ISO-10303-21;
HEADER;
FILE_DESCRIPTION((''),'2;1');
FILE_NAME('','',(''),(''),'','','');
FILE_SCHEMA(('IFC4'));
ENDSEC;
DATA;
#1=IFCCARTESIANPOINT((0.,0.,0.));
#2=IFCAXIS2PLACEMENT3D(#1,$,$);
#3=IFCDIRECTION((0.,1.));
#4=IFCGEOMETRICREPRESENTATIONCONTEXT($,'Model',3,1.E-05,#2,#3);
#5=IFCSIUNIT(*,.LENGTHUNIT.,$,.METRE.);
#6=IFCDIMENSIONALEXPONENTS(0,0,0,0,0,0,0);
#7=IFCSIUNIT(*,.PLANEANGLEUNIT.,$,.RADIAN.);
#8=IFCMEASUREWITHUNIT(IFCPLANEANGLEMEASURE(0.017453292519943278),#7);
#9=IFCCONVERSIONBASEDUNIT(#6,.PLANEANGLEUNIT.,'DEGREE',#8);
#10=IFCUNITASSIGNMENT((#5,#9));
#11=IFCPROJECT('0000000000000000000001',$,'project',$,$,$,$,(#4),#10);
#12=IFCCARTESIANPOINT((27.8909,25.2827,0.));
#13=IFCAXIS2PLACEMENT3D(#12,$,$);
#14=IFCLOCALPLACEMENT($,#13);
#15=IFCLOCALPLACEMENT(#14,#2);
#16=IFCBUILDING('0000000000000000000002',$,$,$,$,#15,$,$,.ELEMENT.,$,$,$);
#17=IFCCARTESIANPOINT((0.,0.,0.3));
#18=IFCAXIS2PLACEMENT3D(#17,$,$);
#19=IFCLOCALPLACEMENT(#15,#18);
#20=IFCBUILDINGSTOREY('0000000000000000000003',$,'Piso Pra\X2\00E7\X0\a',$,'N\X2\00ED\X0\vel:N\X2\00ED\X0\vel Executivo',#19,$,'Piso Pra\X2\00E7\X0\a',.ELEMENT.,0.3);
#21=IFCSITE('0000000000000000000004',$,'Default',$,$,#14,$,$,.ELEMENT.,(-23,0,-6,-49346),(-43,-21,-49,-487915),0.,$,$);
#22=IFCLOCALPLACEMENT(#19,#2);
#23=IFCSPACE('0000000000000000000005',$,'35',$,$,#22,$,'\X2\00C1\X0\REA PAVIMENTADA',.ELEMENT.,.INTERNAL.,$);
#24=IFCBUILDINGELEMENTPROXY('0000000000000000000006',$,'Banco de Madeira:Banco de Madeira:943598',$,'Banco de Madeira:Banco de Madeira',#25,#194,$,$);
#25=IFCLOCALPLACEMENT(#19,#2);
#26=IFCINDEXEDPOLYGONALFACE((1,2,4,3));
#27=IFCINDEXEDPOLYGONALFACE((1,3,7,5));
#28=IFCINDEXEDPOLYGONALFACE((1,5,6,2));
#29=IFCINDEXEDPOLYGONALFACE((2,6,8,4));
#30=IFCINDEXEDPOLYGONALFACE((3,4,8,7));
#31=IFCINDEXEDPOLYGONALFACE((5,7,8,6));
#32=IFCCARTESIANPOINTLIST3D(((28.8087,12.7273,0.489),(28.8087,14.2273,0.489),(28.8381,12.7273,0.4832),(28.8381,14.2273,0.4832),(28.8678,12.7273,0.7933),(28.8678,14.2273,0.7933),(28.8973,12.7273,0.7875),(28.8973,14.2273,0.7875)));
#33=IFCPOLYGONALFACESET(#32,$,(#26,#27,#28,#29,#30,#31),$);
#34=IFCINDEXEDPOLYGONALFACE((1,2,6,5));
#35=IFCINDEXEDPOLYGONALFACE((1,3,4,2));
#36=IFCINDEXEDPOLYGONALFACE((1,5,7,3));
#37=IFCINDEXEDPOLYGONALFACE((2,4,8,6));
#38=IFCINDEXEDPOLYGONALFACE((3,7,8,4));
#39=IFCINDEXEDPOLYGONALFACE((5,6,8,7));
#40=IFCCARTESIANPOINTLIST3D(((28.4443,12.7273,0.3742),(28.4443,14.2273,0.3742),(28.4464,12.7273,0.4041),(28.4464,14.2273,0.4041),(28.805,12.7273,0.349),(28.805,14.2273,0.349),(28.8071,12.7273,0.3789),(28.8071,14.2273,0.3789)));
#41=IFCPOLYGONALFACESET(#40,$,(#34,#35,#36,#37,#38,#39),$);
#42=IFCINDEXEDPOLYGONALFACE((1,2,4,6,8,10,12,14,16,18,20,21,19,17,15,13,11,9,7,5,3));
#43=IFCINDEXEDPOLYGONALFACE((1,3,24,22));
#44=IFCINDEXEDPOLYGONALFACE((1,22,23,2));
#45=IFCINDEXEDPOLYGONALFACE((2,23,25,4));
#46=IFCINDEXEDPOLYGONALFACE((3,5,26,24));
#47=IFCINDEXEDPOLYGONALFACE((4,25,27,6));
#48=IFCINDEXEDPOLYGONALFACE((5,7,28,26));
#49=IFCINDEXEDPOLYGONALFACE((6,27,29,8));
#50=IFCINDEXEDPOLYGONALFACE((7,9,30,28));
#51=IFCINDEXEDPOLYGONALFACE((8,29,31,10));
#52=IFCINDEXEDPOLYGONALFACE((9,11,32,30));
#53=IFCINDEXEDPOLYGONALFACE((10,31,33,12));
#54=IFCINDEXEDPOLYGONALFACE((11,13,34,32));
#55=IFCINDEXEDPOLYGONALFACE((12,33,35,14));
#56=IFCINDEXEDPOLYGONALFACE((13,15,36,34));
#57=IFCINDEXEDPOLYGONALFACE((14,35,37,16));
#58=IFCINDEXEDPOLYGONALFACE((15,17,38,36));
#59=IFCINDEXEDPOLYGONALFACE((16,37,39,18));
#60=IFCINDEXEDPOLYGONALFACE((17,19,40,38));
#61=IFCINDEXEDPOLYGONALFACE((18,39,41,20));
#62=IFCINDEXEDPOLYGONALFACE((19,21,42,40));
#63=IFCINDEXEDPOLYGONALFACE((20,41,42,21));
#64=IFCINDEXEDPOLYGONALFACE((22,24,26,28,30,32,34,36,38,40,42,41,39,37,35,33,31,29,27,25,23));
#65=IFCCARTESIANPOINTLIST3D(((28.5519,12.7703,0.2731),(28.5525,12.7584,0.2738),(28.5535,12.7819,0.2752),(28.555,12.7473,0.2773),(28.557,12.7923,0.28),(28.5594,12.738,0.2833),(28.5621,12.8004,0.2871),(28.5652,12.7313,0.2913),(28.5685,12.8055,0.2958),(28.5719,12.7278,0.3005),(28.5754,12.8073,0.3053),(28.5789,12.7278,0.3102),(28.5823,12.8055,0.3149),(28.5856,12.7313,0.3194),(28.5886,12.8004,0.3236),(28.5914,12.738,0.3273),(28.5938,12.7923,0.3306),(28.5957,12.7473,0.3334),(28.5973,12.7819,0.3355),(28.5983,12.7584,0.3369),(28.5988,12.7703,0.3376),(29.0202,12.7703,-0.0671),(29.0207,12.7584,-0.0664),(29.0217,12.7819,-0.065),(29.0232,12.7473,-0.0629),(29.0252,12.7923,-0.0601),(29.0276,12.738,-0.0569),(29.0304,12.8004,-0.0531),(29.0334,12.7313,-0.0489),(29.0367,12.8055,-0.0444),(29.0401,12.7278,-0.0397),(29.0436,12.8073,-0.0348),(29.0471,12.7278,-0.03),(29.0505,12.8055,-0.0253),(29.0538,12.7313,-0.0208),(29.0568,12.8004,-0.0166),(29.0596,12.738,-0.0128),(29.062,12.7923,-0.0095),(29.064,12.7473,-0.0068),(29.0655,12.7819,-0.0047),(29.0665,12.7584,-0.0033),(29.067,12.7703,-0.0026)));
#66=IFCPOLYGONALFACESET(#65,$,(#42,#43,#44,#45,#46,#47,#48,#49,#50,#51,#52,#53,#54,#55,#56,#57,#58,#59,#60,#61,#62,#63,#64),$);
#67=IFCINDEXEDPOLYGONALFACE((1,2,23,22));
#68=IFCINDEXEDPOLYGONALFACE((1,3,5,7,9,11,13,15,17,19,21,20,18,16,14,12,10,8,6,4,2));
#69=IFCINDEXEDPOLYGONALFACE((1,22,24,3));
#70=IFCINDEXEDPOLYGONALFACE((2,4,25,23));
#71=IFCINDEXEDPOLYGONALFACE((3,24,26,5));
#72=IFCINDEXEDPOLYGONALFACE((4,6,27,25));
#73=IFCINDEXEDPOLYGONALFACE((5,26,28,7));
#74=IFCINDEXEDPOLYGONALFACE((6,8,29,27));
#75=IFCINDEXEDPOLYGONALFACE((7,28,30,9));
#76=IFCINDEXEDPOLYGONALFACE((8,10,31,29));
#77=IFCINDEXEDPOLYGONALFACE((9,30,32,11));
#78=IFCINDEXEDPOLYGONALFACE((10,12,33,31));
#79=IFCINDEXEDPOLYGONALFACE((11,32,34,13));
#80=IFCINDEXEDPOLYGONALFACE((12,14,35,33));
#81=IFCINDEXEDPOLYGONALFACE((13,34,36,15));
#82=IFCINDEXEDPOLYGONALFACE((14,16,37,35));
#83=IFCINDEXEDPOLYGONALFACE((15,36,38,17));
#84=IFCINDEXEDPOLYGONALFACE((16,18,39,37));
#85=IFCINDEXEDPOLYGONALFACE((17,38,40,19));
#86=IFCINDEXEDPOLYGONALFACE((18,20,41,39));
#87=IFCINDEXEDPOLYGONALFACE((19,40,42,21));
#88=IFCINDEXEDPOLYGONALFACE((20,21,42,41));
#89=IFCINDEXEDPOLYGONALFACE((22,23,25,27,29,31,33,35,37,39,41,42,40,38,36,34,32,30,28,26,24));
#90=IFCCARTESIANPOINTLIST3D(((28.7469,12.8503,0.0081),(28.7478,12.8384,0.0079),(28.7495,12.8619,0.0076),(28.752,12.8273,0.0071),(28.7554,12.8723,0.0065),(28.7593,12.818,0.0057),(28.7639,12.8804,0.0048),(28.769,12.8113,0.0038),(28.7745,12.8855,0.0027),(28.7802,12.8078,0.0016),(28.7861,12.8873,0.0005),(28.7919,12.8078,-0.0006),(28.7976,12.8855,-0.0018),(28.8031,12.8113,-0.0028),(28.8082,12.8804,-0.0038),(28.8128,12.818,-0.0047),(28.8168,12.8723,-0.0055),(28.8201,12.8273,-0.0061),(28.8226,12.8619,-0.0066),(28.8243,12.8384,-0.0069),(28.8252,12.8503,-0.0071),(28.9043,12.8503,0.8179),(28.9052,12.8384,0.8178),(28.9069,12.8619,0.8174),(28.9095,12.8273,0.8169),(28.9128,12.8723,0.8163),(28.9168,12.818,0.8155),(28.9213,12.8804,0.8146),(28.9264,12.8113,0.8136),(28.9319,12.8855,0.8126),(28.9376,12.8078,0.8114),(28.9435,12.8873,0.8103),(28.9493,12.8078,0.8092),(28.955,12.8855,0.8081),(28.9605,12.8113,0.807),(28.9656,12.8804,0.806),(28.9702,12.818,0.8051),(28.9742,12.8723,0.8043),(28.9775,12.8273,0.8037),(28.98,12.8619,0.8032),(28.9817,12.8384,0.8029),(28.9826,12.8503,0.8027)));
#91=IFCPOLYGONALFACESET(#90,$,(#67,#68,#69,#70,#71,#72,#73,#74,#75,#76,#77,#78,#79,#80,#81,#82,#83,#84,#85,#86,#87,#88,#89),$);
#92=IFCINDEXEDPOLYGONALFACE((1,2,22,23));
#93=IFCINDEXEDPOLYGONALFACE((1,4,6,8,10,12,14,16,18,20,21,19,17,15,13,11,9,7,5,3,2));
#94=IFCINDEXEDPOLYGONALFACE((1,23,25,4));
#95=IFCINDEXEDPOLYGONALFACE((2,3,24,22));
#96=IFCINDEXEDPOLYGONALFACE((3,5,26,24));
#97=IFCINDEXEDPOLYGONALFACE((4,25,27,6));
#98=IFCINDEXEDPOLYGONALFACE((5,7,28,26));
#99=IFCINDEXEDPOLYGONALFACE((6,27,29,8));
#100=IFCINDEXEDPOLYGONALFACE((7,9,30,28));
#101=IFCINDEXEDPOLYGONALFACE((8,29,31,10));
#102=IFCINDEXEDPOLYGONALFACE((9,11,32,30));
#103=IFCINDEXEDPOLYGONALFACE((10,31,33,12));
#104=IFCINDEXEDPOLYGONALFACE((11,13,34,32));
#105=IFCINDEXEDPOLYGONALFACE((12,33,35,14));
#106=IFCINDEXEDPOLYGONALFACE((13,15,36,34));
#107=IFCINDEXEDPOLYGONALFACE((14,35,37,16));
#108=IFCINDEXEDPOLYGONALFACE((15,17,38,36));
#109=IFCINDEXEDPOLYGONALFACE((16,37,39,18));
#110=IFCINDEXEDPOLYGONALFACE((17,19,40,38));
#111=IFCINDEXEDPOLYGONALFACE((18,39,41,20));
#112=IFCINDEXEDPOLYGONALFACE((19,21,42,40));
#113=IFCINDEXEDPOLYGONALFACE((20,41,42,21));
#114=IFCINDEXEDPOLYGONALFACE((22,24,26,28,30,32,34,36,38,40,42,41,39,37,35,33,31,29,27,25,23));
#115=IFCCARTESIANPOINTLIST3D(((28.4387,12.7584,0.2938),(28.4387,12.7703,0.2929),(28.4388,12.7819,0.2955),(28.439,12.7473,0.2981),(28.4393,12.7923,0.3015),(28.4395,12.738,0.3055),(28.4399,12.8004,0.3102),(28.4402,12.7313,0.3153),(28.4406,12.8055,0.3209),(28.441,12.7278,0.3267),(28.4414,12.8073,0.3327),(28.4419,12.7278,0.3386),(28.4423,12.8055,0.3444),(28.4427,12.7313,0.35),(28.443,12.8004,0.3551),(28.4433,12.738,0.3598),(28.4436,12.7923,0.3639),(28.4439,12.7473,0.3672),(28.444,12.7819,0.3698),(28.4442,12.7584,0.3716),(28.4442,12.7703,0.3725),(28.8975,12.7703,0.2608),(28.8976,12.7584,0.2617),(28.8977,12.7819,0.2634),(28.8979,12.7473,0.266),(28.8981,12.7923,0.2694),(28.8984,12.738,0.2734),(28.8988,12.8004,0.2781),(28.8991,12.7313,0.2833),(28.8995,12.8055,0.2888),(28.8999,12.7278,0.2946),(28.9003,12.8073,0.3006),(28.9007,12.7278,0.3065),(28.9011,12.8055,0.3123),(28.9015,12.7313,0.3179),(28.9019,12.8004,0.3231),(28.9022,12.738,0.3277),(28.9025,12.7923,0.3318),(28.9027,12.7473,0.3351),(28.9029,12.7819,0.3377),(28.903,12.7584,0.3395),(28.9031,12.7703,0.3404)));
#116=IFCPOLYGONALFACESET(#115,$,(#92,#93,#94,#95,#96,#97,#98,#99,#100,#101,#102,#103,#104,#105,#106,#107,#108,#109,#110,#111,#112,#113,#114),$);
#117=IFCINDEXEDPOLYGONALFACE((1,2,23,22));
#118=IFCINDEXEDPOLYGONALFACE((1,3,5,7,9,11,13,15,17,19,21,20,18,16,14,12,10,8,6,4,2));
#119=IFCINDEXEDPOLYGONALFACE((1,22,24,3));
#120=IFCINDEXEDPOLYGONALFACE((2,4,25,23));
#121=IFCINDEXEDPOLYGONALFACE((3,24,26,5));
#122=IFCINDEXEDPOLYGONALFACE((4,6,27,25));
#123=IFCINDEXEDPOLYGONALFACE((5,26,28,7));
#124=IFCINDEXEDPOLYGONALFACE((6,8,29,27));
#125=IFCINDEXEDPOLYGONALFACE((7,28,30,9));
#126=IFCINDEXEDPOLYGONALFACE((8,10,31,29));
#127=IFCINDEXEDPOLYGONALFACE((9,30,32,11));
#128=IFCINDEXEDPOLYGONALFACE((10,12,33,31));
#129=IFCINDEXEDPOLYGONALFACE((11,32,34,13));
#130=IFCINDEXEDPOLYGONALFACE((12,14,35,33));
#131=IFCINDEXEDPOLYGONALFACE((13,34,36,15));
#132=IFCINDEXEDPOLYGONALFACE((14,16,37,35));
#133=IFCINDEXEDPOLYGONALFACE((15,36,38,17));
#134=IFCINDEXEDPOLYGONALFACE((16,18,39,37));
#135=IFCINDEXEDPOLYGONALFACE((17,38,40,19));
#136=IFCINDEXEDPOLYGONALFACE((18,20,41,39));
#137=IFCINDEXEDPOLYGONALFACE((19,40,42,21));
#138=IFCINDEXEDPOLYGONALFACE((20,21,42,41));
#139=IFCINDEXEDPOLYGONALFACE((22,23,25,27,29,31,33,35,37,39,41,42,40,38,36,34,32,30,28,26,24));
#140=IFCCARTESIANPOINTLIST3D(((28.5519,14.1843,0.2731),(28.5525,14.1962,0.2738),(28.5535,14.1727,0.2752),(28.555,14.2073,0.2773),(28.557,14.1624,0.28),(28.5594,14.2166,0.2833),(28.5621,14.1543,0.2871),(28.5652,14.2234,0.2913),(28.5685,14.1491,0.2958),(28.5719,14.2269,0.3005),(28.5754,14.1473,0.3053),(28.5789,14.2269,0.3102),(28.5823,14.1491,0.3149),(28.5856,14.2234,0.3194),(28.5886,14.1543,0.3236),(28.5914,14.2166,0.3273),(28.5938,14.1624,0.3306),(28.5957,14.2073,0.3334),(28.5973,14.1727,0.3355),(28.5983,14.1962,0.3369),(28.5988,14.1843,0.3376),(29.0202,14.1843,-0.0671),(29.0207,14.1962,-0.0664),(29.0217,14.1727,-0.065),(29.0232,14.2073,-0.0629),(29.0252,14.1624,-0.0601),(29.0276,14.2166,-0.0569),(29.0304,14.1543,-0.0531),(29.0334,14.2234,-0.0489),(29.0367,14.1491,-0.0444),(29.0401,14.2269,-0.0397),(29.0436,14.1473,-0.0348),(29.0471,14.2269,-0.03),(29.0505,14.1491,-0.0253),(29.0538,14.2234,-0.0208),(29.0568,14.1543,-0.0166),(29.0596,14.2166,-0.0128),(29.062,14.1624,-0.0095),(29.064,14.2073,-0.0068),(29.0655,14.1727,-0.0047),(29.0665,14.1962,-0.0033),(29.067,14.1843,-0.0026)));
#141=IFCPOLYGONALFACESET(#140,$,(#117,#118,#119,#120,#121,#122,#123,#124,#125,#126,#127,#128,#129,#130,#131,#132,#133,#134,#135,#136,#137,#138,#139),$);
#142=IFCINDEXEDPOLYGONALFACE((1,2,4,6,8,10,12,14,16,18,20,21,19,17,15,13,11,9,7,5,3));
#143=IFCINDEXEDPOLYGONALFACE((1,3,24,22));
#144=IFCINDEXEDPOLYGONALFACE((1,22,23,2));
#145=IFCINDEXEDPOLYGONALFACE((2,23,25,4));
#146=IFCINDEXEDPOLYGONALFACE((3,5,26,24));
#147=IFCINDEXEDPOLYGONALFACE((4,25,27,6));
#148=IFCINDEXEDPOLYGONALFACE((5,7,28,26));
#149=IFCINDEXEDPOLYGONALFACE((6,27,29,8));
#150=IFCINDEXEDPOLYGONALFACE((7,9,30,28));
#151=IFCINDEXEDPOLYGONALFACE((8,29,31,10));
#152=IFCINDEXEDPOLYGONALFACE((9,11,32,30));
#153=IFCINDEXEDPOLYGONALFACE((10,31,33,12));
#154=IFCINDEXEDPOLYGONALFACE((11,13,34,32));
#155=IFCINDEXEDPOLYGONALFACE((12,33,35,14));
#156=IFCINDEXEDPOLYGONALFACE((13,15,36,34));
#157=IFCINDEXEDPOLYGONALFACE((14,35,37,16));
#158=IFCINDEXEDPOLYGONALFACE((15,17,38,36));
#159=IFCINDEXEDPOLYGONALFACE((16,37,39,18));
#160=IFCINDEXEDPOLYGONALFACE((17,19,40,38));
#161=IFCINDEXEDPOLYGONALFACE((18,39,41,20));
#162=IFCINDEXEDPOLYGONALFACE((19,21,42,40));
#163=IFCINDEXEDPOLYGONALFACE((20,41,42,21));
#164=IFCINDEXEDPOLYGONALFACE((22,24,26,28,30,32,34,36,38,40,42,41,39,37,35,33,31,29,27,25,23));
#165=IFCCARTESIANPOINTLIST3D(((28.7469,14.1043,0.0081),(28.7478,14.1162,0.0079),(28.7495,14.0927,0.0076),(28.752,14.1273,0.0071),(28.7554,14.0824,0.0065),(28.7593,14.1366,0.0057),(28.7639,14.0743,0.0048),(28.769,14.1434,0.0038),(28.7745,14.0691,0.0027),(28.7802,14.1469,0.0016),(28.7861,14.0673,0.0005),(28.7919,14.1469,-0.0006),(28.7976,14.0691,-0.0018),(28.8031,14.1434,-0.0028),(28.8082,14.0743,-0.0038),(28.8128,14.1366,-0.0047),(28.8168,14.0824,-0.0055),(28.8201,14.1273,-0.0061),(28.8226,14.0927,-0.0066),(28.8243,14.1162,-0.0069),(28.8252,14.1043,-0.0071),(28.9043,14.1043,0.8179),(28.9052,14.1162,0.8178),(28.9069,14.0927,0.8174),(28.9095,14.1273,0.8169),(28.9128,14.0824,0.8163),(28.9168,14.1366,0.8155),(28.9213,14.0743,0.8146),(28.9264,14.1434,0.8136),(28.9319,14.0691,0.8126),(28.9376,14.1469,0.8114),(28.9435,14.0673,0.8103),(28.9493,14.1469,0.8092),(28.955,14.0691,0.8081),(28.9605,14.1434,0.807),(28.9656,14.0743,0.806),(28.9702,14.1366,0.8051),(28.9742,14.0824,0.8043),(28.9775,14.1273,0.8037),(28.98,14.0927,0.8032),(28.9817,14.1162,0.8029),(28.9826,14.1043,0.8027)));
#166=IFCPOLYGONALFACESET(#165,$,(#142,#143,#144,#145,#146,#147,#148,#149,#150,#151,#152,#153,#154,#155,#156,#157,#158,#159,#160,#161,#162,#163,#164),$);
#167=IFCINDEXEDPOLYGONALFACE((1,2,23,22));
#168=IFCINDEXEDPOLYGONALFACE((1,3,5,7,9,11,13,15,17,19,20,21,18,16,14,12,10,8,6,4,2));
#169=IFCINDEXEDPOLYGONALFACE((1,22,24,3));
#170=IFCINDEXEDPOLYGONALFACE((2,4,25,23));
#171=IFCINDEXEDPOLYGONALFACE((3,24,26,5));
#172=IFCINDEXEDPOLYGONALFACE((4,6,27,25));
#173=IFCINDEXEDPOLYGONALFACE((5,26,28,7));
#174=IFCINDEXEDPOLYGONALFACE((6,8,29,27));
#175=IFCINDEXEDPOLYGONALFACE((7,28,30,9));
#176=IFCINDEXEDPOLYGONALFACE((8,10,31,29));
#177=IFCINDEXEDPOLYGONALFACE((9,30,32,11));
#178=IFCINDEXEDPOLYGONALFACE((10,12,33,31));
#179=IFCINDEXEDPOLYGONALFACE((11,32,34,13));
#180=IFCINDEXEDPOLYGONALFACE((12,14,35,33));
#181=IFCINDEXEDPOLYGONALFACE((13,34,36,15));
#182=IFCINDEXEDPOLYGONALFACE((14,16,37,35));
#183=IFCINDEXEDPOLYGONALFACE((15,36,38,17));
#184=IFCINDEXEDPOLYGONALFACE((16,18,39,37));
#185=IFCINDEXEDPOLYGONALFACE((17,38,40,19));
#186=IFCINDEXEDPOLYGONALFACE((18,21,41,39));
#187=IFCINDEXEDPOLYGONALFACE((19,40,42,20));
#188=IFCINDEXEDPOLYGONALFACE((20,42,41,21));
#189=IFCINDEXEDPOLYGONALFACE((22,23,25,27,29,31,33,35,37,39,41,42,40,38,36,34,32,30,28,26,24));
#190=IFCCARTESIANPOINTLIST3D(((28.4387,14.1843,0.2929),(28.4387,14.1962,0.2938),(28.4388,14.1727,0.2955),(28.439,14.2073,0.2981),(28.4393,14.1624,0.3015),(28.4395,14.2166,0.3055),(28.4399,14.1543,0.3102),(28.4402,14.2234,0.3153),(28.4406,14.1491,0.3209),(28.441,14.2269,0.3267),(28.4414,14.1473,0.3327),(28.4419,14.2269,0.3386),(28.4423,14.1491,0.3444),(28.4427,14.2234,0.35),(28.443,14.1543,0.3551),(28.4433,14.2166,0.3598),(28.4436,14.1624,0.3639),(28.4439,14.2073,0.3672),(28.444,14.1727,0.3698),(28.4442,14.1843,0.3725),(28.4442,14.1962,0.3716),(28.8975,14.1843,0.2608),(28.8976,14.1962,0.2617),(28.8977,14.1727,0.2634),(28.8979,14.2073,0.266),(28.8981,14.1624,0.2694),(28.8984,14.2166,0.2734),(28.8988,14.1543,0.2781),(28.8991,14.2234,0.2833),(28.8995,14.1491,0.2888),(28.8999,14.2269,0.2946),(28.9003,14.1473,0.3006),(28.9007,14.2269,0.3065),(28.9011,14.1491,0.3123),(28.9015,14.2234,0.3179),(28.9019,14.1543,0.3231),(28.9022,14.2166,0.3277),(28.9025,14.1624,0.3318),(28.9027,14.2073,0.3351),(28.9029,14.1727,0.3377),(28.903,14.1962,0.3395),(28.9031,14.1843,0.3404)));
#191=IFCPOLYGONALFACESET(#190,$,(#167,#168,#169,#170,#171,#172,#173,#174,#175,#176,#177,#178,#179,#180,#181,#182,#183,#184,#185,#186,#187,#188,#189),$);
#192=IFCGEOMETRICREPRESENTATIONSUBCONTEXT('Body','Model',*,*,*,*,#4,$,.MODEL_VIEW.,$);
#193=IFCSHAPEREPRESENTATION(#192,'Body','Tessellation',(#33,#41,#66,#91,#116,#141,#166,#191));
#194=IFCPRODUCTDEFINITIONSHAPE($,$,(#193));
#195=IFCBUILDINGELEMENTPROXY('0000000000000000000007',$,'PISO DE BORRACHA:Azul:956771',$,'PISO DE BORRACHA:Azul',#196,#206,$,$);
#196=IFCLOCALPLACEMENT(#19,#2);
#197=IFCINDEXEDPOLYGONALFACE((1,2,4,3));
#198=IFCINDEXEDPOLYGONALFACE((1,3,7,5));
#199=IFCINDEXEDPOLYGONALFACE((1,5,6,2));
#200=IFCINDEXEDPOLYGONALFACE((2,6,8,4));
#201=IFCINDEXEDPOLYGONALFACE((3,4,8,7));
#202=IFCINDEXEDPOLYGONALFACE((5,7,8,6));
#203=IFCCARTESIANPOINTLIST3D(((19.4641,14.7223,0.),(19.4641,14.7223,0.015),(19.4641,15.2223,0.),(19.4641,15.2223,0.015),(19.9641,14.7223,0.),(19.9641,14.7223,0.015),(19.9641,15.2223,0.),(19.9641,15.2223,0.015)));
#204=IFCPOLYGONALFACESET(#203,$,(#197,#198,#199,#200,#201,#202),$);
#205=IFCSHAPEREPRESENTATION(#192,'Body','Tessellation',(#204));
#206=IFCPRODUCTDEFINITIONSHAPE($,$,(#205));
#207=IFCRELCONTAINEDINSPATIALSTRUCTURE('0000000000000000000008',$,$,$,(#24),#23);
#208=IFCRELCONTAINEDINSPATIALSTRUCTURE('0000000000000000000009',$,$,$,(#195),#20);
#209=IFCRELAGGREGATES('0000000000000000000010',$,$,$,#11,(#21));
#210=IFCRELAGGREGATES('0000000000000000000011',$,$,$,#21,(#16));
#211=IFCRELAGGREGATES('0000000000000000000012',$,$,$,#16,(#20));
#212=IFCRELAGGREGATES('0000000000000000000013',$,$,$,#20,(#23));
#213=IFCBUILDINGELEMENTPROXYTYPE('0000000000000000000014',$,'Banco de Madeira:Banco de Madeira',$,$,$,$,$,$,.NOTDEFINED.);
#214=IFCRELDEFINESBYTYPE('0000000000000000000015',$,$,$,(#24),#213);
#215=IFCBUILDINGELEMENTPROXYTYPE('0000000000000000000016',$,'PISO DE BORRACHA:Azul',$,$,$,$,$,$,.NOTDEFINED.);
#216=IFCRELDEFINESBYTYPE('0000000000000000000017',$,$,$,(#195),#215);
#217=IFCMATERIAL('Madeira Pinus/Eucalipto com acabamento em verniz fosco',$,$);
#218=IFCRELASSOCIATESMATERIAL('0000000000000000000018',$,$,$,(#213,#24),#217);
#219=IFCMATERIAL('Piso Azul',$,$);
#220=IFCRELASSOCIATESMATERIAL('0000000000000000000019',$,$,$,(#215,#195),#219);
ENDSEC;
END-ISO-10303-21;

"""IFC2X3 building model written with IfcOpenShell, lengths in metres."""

from ifc_helpers import new_model, entity, si_unit, converted_unit, direction, frame, frame_2d, origin, origin_2d_with_axis, place, context, subcontext, project, spatial, rectangle, circle, extrude, source, transform, mapped, material, type_object, type_shapes, element, save


model = new_model("IFC2X3")

# Units and contexts
model_context = context("Model", 3, precision=1e-05, world=origin(), true_north=direction((0.0, 1.0)))
body_context = subcontext(model_context, "Body", "Model", "MODEL_VIEW")
ifc_project = project(units=[si_unit("LENGTHUNIT", "METRE"), converted_unit("PLANEANGLEUNIT", "DEGREE", entity("IfcPlaneAngleMeasure", 0.017453292519943278), si_unit("PLANEANGLEUNIT", "RADIAN"), dimensions=[0, 0, 0, 0, 0, 0, 0])], contexts=[model_context])

# Site, building, storey, space
site_placement = place(None, frame((27.8909, 25.2827, 0.0)))
site = spatial("IfcSite", under=ifc_project, at=site_placement, Name="Default", CompositionType="ELEMENT", RefLatitude=(-23, 0, -6, -49346), RefLongitude=(-43, -21, -49, -487915), RefElevation=0.0)
building_placement = place(site_placement, origin())
building = spatial("IfcBuilding", under=site, at=building_placement, CompositionType="ELEMENT")
storey_placement = place(building_placement, frame((0.0, 0.0, 0.3)))
storey = spatial("IfcBuildingStorey", under=building, at=storey_placement, Name="Piso Praça", ObjectType="Nível:Nível Executivo", LongName="Piso Praça", CompositionType="ELEMENT", Elevation=0.3)
space_placement = place(storey_placement, origin())
space = spatial("IfcSpace", under=storey, at=space_placement, Name="35", LongName="ÁREA PAVIMENTADA", CompositionType="ELEMENT", InteriorOrExteriorSpace="INTERNAL")

# Building element proxies
ifc_material_1 = material(Name="Madeira Pinus/Eucalipto com acabamento em verniz fosco")
building_element_proxy_type_1 = type_object("IfcBuildingElementProxyType", Name="Banco de Madeira:Banco de Madeira", PredefinedType="NOTDEFINED", material=ifc_material_1)
shared_shape_1 = source(origin(), body_context, "Body", "SweptSolid", [
    extrude(rectangle(XDim=0.31, YDim=0.03, at=frame_2d((0.0, 0.0), x_axis=(1.0, 0.0))), frame((-0.75, 0.1439, 0.6383), z_axis=(1.0, 0.0, 0.0), x_axis=(0.0, 0.190809, 0.981627)), (0.0, 0.0, 1.0), 1.5),
    extrude(rectangle(XDim=0.03, YDim=0.3616, at=frame_2d((0.0, 0.0), x_axis=(0.0, 1.0))), frame((-0.75, -0.0833, 0.3765), z_axis=(1.0, 0.0, 0.0), x_axis=(0.0, 0.997564, -0.069756)), (0.0, 0.0, 1.0), 1.5),
    extrude(circle(Radius=0.04, at=frame_2d((0.0, 0.0), x_axis=(1.0, 0.0))), frame((0.71, 0.3345, -0.0348), z_axis=(0.0, -0.809017, 0.587785), x_axis=(-1.0, 0.0, 0.0)), (0.0, 0.0, 1.0), 0.5788),
    extrude(circle(Radius=0.04, at=frame_2d((0.0, 0.0), x_axis=(1.0, 0.0))), frame((0.63, 0.077, 0.0005), z_axis=(0.0, 0.190809, 0.981627), x_axis=(-1.0, 0.0, 0.0)), (0.0, 0.0, 1.0), 0.825),
    extrude(circle(Radius=0.04, at=frame_2d((0.0, 0.0), x_axis=(1.0, 0.0))), frame((0.71, -0.2676, 0.3327), z_axis=(0.0, 0.997564, -0.069756), x_axis=(-1.0, 0.0, 0.0)), (0.0, 0.0, 1.0), 0.46),
    extrude(circle(Radius=0.04, at=frame_2d((0.0, 0.0), x_axis=(1.0, 0.0))), frame((-0.71, 0.3345, -0.0348), z_axis=(0.0, -0.809017, 0.587785), x_axis=(1.0, 0.0, 0.0)), (0.0, 0.0, 1.0), 0.5788),
    extrude(circle(Radius=0.04, at=frame_2d((0.0, 0.0), x_axis=(1.0, 0.0))), frame((-0.63, 0.077, 0.0005), z_axis=(0.0, 0.190809, 0.981627), x_axis=(1.0, 0.0, 0.0)), (0.0, 0.0, 1.0), 0.825),
    extrude(circle(Radius=0.04, at=frame_2d((0.0, 0.0), x_axis=(1.0, 0.0))), frame((-0.71, -0.2676, 0.3327), z_axis=(0.0, 0.997564, -0.069756), x_axis=(1.0, 0.0, 0.0)), (0.0, 0.0, 1.0), 0.46),
])
type_shapes(building_element_proxy_type_1, [shared_shape_1])
proxy_placement = place(space_placement, frame((28.7091, 13.4773, 0.0), z_axis=(0.0, 0.0, 1.0), x_axis=(0.0, -1.0, 0.0)))
element("IfcBuildingElementProxy", 1, at=proxy_placement, inside=space, type_object=building_element_proxy_type_1, material=ifc_material_1, Name="Banco de Madeira:Banco de Madeira:943598", ObjectType="Banco de Madeira:Banco de Madeira", context=body_context, shape_type="MappedRepresentation", body=[
    mapped(shared_shape_1, transform((0.0, 0.0, 0.0), scale=1.0)),
])
ifc_material_2 = material(Name="Piso Azul")
building_element_proxy_type_2 = type_object("IfcBuildingElementProxyType", Name="PISO DE BORRACHA:Azul", PredefinedType="NOTDEFINED", material=ifc_material_2)
shared_shape_2 = source(origin(), body_context, "Body", "SweptSolid", [
    extrude(rectangle(XDim=0.5, YDim=0.5, at=origin_2d_with_axis()), frame((0.25, 0.25, 0.0), z_axis=(0.0, 0.0, 1.0), x_axis=(-1.0, 0.0, 0.0)), (0.0, 0.0, 1.0), 0.015),
])
type_shapes(building_element_proxy_type_2, [shared_shape_2])
for number, where, name in (
    (2, (19.4641, 14.7223, 0.0), "PISO DE BORRACHA:Azul:956771"),
):
    element("IfcBuildingElementProxy", number, at=place(storey_placement, frame(where)), inside=storey, type_object=building_element_proxy_type_2, material=ifc_material_2, Name=name, ObjectType="PISO DE BORRACHA:Azul", context=body_context, shape_type="MappedRepresentation", body=[
        mapped(shared_shape_2, transform((0.0, 0.0, 0.0), scale=1.0)),
    ])

save(model, "model.ifc")
